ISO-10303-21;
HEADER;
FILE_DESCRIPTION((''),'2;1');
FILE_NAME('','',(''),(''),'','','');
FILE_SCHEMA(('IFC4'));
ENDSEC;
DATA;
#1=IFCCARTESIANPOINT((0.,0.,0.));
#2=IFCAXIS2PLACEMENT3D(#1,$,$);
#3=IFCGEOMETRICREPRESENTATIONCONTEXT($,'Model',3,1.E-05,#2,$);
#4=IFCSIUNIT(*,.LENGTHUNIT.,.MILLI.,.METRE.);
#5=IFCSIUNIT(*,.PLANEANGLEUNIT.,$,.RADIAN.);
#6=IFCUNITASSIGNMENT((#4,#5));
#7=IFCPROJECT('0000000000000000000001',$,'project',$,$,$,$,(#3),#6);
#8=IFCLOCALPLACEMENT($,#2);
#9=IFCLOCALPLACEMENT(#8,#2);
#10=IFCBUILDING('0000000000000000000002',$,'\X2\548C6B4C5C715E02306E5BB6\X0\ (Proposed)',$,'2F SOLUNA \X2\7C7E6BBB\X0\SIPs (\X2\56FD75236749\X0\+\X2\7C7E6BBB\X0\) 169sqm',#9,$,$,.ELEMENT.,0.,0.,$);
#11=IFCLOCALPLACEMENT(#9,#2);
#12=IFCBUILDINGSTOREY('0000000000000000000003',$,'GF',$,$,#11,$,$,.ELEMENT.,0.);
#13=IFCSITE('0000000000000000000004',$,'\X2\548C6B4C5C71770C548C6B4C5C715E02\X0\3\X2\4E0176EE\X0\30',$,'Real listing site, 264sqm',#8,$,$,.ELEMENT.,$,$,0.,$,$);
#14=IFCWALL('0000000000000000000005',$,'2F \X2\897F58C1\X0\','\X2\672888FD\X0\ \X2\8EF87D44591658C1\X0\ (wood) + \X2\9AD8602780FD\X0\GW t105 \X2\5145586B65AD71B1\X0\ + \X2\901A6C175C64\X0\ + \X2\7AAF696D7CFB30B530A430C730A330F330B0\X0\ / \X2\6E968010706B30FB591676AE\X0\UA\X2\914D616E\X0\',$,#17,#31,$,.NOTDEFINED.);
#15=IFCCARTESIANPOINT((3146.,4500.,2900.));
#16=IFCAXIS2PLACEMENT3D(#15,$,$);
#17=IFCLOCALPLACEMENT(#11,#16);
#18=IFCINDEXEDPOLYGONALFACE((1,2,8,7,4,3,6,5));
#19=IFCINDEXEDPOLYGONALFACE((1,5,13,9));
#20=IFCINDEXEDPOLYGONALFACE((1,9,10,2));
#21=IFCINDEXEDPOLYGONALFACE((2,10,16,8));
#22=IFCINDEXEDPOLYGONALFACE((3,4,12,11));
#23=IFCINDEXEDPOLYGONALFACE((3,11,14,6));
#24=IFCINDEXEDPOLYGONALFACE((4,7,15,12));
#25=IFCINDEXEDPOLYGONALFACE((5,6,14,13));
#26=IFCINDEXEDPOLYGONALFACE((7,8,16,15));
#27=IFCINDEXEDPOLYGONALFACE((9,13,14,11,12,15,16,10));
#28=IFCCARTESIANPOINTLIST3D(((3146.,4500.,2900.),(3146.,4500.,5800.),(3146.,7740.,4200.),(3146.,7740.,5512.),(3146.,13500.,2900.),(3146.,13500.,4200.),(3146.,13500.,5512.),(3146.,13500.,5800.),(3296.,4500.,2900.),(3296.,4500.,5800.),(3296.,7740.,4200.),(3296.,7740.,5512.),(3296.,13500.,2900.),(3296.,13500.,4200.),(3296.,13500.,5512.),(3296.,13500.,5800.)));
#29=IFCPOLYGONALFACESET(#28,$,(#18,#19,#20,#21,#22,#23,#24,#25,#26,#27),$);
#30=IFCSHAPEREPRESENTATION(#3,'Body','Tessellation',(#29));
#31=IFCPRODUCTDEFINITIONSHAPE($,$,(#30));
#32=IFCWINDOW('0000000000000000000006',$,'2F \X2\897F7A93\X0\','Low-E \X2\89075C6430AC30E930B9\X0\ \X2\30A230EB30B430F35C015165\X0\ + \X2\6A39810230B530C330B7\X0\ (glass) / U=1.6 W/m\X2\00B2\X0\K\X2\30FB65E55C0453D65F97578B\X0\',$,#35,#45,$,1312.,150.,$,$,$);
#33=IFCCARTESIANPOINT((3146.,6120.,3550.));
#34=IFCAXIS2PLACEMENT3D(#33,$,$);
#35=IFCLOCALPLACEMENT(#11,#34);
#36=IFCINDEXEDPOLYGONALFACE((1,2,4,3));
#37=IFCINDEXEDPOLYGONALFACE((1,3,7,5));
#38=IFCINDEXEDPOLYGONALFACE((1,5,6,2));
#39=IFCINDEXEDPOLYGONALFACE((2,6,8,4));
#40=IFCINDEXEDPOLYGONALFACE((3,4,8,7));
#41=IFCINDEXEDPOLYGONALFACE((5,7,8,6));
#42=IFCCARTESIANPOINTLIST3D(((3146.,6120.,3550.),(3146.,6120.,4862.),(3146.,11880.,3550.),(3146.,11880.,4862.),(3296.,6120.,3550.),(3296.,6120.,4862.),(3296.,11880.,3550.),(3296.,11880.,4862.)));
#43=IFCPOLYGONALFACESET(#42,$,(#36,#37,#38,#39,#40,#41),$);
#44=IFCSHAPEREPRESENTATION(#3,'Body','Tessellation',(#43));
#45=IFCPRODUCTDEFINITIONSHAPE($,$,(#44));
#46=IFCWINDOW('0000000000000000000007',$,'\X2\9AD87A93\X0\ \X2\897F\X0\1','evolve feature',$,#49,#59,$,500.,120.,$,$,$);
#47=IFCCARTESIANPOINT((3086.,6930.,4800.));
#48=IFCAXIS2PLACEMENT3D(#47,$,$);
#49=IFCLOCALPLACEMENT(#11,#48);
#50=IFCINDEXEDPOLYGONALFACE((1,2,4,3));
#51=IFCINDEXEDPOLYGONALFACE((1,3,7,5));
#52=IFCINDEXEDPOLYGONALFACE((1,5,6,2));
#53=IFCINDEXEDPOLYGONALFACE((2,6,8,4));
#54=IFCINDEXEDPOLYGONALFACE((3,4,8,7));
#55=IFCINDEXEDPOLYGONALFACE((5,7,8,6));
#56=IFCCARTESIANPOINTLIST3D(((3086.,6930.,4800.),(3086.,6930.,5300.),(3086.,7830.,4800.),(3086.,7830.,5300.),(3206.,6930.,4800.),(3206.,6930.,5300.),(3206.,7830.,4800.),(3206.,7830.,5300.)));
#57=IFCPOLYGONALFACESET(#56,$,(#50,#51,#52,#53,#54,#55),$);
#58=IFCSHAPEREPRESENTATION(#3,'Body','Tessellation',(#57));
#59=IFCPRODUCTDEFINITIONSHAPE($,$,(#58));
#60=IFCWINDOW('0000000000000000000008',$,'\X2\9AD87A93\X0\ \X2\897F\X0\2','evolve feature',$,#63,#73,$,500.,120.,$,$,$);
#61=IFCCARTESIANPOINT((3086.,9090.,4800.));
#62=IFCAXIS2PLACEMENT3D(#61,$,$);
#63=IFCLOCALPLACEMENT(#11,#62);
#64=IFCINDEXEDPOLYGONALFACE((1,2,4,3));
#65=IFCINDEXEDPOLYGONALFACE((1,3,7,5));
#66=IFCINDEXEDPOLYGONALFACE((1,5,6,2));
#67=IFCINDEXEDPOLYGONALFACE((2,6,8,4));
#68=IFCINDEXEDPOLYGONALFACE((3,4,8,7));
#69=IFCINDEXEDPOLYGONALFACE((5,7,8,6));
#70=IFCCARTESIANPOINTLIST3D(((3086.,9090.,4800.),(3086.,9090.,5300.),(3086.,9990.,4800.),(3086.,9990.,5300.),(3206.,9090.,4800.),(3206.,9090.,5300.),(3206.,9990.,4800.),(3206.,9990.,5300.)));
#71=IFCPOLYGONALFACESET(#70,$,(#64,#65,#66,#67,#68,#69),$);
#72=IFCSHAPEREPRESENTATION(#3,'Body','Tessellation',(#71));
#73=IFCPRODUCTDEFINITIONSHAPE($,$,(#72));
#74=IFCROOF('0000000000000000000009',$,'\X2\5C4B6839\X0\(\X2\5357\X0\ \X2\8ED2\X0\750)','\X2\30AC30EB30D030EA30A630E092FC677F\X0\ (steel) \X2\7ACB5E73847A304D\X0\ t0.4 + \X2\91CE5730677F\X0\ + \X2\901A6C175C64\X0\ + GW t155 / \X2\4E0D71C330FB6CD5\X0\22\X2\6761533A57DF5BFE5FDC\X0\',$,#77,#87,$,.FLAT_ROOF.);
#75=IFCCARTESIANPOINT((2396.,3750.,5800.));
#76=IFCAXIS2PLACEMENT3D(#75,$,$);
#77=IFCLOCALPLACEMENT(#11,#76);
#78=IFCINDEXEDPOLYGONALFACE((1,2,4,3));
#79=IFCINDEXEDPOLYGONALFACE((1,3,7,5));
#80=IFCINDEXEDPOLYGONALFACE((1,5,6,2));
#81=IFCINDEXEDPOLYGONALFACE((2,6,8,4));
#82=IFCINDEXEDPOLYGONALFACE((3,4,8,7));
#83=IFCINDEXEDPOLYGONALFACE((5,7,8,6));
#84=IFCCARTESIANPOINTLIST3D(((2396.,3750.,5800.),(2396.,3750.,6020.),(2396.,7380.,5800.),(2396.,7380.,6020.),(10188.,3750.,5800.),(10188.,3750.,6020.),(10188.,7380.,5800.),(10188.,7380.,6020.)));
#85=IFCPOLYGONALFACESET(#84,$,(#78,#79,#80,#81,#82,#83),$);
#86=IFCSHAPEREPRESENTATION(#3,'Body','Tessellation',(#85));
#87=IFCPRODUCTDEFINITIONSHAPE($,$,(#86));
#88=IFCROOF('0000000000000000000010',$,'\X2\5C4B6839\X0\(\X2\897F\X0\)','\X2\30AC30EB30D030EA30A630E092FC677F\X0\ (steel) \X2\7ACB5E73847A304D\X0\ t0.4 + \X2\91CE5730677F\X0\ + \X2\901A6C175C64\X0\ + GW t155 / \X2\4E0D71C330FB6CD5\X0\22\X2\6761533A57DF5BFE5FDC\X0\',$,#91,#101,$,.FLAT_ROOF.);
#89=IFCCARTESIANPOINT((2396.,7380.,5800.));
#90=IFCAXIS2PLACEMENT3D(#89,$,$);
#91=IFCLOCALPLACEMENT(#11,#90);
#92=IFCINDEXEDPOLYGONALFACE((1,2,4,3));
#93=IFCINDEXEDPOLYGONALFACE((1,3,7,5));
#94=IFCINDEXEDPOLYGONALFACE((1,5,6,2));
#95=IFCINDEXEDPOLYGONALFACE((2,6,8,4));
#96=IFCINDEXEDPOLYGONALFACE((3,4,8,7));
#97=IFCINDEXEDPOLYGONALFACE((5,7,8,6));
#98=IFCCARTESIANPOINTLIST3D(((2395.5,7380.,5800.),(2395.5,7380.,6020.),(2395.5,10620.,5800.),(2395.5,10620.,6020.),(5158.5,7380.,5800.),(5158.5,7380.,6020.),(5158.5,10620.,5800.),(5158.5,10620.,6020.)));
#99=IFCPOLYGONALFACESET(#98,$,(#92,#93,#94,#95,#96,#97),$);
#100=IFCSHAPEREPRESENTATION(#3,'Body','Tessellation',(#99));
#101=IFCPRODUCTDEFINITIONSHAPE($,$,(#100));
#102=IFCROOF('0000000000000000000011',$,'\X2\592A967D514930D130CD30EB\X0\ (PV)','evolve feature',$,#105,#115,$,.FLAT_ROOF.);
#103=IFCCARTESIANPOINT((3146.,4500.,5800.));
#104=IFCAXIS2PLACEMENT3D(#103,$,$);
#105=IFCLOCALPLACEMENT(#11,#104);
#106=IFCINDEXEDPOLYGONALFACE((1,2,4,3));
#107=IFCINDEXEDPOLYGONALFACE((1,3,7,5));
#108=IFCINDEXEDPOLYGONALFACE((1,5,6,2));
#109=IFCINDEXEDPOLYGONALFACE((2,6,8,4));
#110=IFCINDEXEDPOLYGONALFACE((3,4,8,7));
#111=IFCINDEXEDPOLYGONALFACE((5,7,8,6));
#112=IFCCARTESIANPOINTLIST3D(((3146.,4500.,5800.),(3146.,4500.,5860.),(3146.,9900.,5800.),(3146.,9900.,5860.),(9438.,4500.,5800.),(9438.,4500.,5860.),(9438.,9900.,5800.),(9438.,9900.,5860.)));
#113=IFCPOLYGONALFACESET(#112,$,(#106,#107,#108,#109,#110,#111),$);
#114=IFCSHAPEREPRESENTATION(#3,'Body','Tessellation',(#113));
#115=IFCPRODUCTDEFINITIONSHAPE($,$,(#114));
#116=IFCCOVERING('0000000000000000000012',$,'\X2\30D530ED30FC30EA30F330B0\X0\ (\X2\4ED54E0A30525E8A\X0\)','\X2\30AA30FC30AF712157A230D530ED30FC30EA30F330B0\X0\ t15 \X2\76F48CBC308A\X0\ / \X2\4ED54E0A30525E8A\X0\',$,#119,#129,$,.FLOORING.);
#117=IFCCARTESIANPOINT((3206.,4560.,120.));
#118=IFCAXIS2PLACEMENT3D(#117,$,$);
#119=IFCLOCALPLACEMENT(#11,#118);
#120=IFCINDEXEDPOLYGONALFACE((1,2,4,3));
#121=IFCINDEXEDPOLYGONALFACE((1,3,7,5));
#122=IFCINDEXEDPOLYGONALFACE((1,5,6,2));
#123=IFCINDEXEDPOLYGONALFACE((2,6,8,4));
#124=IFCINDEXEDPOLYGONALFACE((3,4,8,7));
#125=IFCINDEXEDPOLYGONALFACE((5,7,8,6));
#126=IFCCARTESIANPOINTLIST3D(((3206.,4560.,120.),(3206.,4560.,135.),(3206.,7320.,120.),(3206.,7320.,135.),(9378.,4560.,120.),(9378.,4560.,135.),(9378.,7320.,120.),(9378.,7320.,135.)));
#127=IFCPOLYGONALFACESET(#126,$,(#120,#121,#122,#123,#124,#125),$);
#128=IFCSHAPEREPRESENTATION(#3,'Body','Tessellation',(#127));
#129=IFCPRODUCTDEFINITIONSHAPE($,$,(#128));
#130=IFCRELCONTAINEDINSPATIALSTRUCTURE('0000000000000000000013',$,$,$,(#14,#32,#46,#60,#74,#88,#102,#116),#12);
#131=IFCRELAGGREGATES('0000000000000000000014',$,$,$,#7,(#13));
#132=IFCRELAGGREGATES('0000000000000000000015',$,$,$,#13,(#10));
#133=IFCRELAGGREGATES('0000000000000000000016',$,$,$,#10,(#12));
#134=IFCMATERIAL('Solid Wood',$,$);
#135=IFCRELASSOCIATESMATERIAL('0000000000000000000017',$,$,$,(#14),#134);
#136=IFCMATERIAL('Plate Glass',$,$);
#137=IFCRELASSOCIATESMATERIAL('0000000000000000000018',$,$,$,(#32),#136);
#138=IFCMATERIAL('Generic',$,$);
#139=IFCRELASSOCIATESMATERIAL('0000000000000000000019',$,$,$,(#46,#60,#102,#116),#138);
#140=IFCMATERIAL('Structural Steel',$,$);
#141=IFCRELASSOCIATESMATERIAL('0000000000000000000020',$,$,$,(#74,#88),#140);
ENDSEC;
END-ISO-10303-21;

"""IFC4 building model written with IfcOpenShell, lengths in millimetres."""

from ifc_helpers import new_model, si_unit, frame, frame_2d, origin, place, context, project, spatial, rectangle, extrude, material, element, fill, save


model = new_model("IFC4")

# Units and contexts
model_context = context("Model", 3, precision=1e-05, world=origin())
ifc_project = project(units=[si_unit("LENGTHUNIT", "METRE", prefix="MILLI"), si_unit("PLANEANGLEUNIT", "RADIAN")], contexts=[model_context])

# Site, building, storey
site_placement = place(None, origin())
site = spatial("IfcSite", under=ifc_project, at=site_placement, Name="和歌山県和歌山市3丁目30", ObjectType="Real listing site, 264sqm", CompositionType="ELEMENT", RefElevation=0.0)
building_placement = place(site_placement, origin())
building = spatial("IfcBuilding", under=site, at=building_placement, Name="和歌山市の家 (Proposed)", ObjectType="2F SOLUNA 籾殻SIPs (国産杉+籾殻) 169sqm", CompositionType="ELEMENT", ElevationOfRefHeight=0.0, ElevationOfTerrain=0.0)
storey_placement = place(building_placement, origin())
storey = spatial("IfcBuildingStorey", under=building, at=storey_placement, Name="GF", CompositionType="ELEMENT", Elevation=0.0)

# Shared definitions
ifc_material_1 = material(Name="Solid Wood")
ifc_material_2 = material(Name="Generic")

# Shared definitions
ifc_material_3 = material(Name="Plate Glass")

# Wall, openings, windows
wall_1_placement = place(storey_placement, frame((3146.0, 4500.0, 2900.0)))
wall_1 = element("IfcWall", 1, at=wall_1_placement, inside=storey, material=ifc_material_1, Name="2F 西壁", Description="木製 軸組外壁 (wood) + 高性能GW t105 充填断熱 + 通気層 + 窯業系サイディング / 準耐火・外皮UA配慮", PredefinedType="NOTDEFINED", context=model_context, shape_type="SweptSolid", body=[
    extrude(rectangle(XDim=150.0, YDim=9000.0, at=frame_2d((75.0, 4500.0))), frame((3146.0, 4500.0, 2900.0)), (0.0, 0.0, 1.0), 2900.0),
])
opening_1_placement = place(storey_placement, frame((3146.0, 6120.0, 3550.0)))
opening_1 = element("IfcOpeningElement", 2, at=opening_1_placement, cuts=wall_1, PredefinedType="NOTDEFINED", context=model_context, shape_type="SweptSolid", body=[
    extrude(rectangle(XDim=150.0, YDim=5760.0, at=frame_2d((75.0, 2880.0))), frame((3146.0, 6120.0, 3550.0)), (0.0, 0.0, 1.0), 1312.0),
])
opening_2_placement = place(storey_placement, frame((3086.0, 6930.0, 4800.0)))
opening_2 = element("IfcOpeningElement", 3, at=opening_2_placement, cuts=wall_1, PredefinedType="NOTDEFINED", context=model_context, shape_type="SweptSolid", body=[
    extrude(rectangle(XDim=120.0, YDim=900.0, at=frame_2d((60.0, 450.0))), frame((3086.0, 6930.0, 4800.0)), (0.0, 0.0, 1.0), 500.0),
])
opening_3_placement = place(storey_placement, frame((3086.0, 9090.0, 4800.0)))
opening_3 = element("IfcOpeningElement", 4, at=opening_3_placement, cuts=wall_1, PredefinedType="NOTDEFINED", context=model_context, shape_type="SweptSolid", body=[
    extrude(rectangle(XDim=120.0, YDim=900.0, at=frame_2d((60.0, 450.0))), frame((3086.0, 9090.0, 4800.0)), (0.0, 0.0, 1.0), 500.0),
])
window_1_placement = place(storey_placement, frame((3146.0, 6120.0, 3550.0)))
window_1 = element("IfcWindow", 5, at=window_1_placement, inside=storey, material=ifc_material_3, Name="2F 西窓", Description="Low-E 複層ガラス アルゴン封入 + 樹脂サッシ (glass) / U=1.6 W/m²K・日射取得型", OverallHeight=1312.0, OverallWidth=150.0, context=model_context, shape_type="SweptSolid", body=[
    extrude(rectangle(XDim=150.0, YDim=5760.0, at=frame_2d((75.0, 2880.0))), frame((3146.0, 6120.0, 3550.0)), (0.0, 0.0, 1.0), 1312.0),
])
fill(opening_1, window_1)
window_2_placement = place(storey_placement, frame((3086.0, 6930.0, 4800.0)))
window_2 = element("IfcWindow", 6, at=window_2_placement, inside=storey, material=ifc_material_2, Name="高窓 西1", Description="evolve feature", OverallHeight=500.0, OverallWidth=120.0, context=model_context, shape_type="SweptSolid", body=[
    extrude(rectangle(XDim=120.0, YDim=900.0, at=frame_2d((60.0, 450.0))), frame((3086.0, 6930.0, 4800.0)), (0.0, 0.0, 1.0), 500.0),
])
fill(opening_2, window_2)
window_3_placement = place(storey_placement, frame((3086.0, 9090.0, 4800.0)))
window_3 = element("IfcWindow", 7, at=window_3_placement, inside=storey, material=ifc_material_2, Name="高窓 西2", Description="evolve feature", OverallHeight=500.0, OverallWidth=120.0, context=model_context, shape_type="SweptSolid", body=[
    extrude(rectangle(XDim=120.0, YDim=900.0, at=frame_2d((60.0, 450.0))), frame((3086.0, 9090.0, 4800.0)), (0.0, 0.0, 1.0), 500.0),
])
fill(opening_3, window_3)

# Roofs
ifc_material_4 = material(Name="Structural Steel")
roof_1_placement = place(storey_placement, frame((2396.0, 3750.0, 5800.0)))
element("IfcRoof", 8, at=roof_1_placement, inside=storey, material=ifc_material_4, Name="屋根(南 軒750)", Description="ガルバリウム鋼板 (steel) 立平葺き t0.4 + 野地板 + 通気層 + GW t155 / 不燃・法22条区域対応", PredefinedType="FLAT_ROOF", context=model_context, shape_type="SweptSolid", body=[
    extrude(rectangle(XDim=7792.0, YDim=3630.0, at=frame_2d((3896.0, 1815.0))), frame((2396.0, 3750.0, 5800.0)), (0.0, 0.0, 1.0), 220.0),
])
roof_2_placement = place(storey_placement, frame((2396.0, 7380.0, 5800.0)))
element("IfcRoof", 9, at=roof_2_placement, inside=storey, material=ifc_material_4, Name="屋根(西)", Description="ガルバリウム鋼板 (steel) 立平葺き t0.4 + 野地板 + 通気層 + GW t155 / 不燃・法22条区域対応", PredefinedType="FLAT_ROOF", context=model_context, shape_type="SweptSolid", body=[
    extrude(rectangle(XDim=2763.0, YDim=3240.0, at=frame_2d((1381.0, 1620.0))), frame((2396.0, 7380.0, 5800.0)), (0.0, 0.0, 1.0), 220.0),
])
roof_3_placement = place(storey_placement, frame((3146.0, 4500.0, 5800.0)))
element("IfcRoof", 10, at=roof_3_placement, inside=storey, material=ifc_material_2, Name="太陽光パネル (PV)", Description="evolve feature", PredefinedType="FLAT_ROOF", context=model_context, shape_type="SweptSolid", body=[
    extrude(rectangle(XDim=6292.0, YDim=5400.0, at=frame_2d((3146.0, 2700.0))), frame((3146.0, 4500.0, 5800.0)), (0.0, 0.0, 1.0), 60.0),
])

# Covering
covering_placement = place(storey_placement, frame((3206.0, 4560.0, 120.0)))
element("IfcCovering", 11, at=covering_placement, inside=storey, material=ifc_material_2, Name="フローリング (仕上げ床)", Description="オーク無垢フローリング t15 直貼り / 仕上げ床", PredefinedType="FLOORING", context=model_context, shape_type="SweptSolid", body=[
    extrude(rectangle(XDim=6172.0, YDim=2760.0, at=frame_2d((3086.0, 1380.0))), frame((3206.0, 4560.0, 120.0)), (0.0, 0.0, 1.0), 15.0),
])

save(model, "model.ifc")
